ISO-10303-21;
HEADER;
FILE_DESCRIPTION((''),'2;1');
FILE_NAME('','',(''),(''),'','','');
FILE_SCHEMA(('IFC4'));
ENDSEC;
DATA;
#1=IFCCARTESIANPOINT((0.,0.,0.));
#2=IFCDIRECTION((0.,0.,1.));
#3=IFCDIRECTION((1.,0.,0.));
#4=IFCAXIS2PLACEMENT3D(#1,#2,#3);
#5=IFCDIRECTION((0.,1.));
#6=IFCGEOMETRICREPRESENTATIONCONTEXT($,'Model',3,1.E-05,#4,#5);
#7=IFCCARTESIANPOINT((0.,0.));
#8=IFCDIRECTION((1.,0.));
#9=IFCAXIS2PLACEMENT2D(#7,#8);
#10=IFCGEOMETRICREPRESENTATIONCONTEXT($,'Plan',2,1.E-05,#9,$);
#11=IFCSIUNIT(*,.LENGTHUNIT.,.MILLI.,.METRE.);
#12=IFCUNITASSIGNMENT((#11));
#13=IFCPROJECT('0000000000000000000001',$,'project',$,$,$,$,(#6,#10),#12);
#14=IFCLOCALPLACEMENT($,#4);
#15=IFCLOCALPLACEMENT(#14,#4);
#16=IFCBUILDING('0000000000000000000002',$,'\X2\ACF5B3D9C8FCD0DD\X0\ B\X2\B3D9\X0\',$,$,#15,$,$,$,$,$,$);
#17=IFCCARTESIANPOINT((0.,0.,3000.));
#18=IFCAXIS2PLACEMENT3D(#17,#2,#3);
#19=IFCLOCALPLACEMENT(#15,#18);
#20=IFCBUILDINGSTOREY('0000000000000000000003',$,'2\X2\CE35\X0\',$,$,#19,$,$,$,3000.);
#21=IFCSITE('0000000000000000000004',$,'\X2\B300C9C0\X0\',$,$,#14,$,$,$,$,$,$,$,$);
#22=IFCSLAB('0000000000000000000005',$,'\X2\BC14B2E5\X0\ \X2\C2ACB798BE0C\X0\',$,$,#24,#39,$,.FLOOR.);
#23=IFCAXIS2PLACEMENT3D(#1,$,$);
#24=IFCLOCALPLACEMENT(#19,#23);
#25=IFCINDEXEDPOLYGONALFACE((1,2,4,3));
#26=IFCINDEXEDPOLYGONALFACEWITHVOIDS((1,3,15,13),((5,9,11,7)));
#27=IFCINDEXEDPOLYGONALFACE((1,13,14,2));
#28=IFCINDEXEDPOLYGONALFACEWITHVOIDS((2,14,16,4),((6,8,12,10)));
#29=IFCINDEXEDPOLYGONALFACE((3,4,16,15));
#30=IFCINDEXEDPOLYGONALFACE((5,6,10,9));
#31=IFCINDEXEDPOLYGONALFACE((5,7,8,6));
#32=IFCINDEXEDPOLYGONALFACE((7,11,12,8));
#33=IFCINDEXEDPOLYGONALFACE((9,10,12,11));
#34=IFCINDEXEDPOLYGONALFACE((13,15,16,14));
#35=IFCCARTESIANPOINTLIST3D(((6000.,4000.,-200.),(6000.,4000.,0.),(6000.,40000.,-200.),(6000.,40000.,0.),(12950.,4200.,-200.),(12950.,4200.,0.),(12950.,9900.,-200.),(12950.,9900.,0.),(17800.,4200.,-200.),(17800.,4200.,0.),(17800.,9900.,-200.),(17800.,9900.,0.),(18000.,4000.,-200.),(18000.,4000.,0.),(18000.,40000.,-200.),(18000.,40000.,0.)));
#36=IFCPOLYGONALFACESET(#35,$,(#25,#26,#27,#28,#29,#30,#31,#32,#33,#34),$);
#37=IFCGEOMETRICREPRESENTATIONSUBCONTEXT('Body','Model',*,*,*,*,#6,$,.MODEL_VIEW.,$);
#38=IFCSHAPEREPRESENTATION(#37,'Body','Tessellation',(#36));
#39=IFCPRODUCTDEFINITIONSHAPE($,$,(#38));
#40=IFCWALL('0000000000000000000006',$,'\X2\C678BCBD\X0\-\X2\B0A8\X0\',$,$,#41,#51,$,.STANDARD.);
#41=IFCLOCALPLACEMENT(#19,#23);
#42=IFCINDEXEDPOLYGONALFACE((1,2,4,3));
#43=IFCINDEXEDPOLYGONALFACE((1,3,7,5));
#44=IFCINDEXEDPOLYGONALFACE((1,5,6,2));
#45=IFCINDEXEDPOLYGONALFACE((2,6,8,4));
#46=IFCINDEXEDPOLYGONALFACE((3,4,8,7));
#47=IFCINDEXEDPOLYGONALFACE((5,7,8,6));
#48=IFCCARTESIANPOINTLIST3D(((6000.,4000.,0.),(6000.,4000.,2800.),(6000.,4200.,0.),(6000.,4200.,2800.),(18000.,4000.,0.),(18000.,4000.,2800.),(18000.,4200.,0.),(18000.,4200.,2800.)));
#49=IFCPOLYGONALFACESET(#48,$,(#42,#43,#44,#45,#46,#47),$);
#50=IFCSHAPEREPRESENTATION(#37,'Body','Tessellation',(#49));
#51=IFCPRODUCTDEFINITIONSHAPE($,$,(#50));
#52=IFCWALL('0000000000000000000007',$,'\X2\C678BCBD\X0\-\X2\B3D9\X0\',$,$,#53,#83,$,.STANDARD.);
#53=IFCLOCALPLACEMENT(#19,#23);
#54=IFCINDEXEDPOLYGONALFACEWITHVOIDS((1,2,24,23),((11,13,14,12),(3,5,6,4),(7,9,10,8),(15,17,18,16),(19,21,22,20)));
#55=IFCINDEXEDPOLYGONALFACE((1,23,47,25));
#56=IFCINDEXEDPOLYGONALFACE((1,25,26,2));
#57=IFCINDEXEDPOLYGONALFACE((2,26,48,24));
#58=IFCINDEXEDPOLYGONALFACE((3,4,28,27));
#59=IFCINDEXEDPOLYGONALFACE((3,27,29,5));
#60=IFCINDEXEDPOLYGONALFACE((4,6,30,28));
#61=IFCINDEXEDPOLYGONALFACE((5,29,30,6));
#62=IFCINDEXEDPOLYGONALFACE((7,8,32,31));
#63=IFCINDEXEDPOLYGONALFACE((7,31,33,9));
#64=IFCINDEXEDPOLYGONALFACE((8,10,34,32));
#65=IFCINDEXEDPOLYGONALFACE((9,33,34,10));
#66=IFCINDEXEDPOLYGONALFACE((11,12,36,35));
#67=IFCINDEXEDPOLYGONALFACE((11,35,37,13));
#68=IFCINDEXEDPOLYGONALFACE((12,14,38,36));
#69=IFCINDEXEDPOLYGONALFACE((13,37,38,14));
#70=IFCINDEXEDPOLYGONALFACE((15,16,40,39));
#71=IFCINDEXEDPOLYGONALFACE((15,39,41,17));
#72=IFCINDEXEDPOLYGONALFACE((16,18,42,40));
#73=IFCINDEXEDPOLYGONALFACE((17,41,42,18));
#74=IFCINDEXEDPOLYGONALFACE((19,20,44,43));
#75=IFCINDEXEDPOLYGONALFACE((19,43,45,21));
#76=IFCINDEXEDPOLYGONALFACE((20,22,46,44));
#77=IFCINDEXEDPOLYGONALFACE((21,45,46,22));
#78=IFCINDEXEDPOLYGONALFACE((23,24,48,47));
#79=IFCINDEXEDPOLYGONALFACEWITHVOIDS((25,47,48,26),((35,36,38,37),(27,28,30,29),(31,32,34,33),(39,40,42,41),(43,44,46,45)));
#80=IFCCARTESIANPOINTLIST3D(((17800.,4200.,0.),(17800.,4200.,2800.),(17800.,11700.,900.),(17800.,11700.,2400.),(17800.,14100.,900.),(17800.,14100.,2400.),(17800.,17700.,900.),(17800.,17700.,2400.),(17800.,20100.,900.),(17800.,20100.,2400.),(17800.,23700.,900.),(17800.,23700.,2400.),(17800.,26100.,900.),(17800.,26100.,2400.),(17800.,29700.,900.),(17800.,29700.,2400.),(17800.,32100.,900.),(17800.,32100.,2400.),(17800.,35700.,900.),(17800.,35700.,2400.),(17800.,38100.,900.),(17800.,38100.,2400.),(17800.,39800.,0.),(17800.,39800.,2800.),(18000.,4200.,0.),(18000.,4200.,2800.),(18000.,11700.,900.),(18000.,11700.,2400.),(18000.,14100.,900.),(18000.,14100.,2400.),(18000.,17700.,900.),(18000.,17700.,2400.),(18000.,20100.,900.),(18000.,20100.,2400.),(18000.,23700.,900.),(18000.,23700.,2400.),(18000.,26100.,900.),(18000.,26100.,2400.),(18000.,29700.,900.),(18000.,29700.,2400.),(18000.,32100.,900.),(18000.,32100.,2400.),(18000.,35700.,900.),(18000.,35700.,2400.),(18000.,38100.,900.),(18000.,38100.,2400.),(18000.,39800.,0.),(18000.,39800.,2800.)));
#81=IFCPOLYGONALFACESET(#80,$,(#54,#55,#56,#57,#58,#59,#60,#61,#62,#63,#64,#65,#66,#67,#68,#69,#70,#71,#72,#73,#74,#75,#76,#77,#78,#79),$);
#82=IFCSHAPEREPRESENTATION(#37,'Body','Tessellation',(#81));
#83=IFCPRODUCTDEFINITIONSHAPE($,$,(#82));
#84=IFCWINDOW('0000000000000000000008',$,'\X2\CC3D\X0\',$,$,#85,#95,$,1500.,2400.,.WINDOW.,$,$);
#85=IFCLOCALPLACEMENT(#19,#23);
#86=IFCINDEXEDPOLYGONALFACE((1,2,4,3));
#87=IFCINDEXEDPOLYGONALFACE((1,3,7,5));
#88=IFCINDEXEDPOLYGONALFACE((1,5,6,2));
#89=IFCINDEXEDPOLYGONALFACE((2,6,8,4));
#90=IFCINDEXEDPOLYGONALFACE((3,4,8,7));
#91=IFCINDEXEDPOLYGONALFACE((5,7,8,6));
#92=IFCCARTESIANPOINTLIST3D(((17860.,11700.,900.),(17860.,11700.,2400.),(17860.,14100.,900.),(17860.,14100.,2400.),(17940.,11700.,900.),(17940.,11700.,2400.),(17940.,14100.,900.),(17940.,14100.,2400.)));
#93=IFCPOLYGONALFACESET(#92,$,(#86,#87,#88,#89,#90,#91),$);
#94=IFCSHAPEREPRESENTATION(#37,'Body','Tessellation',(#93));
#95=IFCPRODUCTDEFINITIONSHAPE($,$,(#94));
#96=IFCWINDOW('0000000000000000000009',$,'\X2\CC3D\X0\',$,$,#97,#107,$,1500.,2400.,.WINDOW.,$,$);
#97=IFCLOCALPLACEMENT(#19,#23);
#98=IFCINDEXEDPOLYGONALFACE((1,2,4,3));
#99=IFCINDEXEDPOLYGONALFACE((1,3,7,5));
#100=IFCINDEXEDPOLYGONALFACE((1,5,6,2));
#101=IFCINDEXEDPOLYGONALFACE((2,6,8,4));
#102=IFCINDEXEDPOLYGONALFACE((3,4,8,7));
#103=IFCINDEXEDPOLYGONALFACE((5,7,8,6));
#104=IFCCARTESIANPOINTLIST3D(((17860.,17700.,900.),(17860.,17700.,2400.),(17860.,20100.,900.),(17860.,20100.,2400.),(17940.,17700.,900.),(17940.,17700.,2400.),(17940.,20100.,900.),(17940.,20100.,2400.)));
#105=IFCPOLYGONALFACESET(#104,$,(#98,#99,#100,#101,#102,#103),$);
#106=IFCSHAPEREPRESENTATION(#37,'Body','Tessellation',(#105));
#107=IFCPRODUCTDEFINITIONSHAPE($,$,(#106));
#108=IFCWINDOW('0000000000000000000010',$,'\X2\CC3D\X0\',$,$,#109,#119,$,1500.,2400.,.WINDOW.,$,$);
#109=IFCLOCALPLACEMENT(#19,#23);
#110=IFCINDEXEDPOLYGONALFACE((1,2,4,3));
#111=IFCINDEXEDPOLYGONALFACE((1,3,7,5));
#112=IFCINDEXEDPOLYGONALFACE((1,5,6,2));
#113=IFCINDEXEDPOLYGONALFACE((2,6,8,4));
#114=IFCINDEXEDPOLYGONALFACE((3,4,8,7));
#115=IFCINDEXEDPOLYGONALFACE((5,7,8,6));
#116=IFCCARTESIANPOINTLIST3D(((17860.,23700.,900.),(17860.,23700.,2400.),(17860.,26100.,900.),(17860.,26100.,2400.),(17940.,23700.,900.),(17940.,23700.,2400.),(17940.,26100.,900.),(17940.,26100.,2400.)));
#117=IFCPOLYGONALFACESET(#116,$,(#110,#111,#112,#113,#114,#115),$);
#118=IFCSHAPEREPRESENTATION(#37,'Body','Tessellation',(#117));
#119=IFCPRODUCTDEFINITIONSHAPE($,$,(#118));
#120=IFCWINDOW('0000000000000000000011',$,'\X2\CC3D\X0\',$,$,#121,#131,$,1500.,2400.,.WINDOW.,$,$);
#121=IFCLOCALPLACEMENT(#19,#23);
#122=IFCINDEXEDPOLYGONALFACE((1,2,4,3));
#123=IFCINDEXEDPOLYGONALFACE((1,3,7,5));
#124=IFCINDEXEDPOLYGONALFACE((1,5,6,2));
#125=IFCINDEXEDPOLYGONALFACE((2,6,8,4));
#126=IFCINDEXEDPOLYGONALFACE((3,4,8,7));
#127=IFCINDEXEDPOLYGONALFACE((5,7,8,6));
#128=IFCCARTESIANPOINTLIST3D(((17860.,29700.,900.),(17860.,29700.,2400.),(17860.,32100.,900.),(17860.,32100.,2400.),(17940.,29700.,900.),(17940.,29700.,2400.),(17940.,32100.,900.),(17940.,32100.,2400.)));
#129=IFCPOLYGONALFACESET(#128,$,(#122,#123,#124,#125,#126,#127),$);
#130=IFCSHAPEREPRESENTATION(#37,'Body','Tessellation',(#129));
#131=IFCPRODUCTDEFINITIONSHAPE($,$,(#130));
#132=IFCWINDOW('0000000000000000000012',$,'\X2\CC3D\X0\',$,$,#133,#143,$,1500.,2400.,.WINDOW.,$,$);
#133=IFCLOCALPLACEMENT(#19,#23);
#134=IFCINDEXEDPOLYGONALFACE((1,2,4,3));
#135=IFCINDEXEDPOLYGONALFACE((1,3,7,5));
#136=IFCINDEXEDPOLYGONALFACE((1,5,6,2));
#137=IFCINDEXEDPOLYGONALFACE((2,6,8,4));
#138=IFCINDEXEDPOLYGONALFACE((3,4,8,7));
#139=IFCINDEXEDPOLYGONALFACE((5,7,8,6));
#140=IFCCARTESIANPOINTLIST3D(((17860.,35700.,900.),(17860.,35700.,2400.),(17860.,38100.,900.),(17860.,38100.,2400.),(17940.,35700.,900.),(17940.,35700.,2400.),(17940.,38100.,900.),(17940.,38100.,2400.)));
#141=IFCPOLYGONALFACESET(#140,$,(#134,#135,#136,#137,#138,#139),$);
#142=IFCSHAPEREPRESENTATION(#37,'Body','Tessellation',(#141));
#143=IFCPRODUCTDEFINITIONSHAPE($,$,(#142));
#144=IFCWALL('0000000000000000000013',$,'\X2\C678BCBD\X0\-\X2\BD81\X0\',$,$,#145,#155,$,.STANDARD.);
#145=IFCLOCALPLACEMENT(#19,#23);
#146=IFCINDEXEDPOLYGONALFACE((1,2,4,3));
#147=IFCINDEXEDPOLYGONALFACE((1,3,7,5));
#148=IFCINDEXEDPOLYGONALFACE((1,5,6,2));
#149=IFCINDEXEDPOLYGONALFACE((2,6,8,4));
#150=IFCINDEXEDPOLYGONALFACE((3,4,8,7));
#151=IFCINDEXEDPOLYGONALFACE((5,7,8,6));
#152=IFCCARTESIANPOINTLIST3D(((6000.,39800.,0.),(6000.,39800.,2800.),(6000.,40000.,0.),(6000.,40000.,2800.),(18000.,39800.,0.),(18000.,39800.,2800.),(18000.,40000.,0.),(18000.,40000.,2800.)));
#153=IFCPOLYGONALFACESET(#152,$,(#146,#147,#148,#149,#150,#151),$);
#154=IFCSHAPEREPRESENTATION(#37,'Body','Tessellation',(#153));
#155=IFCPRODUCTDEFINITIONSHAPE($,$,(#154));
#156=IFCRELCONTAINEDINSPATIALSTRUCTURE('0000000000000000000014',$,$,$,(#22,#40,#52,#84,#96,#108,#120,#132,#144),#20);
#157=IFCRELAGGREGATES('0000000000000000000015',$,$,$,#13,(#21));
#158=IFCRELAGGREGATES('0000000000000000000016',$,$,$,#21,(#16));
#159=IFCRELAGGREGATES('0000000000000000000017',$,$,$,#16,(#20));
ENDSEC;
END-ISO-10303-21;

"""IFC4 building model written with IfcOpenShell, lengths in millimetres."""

from ifc_helpers import new_model, si_unit, direction, frame, origin_with_axes, origin_2d_with_axis, place, context, subcontext, project, spatial, polyline, outline, extrude, element, fill, save


model = new_model("IFC4")

# Units and contexts
model_context = context("Model", 3, precision=1e-05, world=origin_with_axes(), true_north=direction((0.0, 1.0)))
plan_context = context("Plan", 2, precision=1e-05, world=origin_2d_with_axis())
body_context = subcontext(model_context, "Body", "Model", "MODEL_VIEW")
ifc_project = project(units=[si_unit("LENGTHUNIT", "METRE", prefix="MILLI")], contexts=[model_context, plan_context])

# Site, building, storey
site_placement = place(None, origin_with_axes())
site = spatial("IfcSite", under=ifc_project, at=site_placement, Name="대지")
building_placement = place(site_placement, origin_with_axes())
building = spatial("IfcBuilding", under=site, at=building_placement, Name="공동주택 B동")
storey_placement = place(building_placement, frame((0.0, 0.0, 3000.0), z_axis=(0.0, 0.0, 1.0), x_axis=(1.0, 0.0, 0.0)))
storey = spatial("IfcBuildingStorey", under=building, at=storey_placement, Name="2층", Elevation=3000.0)

# Slab
slab_placement = place(storey_placement, origin_with_axes())
element("IfcSlab", 1, at=slab_placement, inside=storey, Name="바닥 슬래브", PredefinedType="FLOOR", context=body_context, shape_type="SweptSolid", body=[
    extrude(outline(polyline([(6000.0, 4000.0), (18000.0, 4000.0), (18000.0, 40000.0), (6000.0, 40000.0), (6000.0, 4000.0)]), holes=[polyline([(12950.0, 4200.0), (17800.0, 4200.0), (17800.0, 9900.0), (12950.0, 9900.0), (12950.0, 4200.0)])]), frame((0.0, 0.0, -200.0), z_axis=(0.0, 0.0, 1.0), x_axis=(1.0, 0.0, 0.0)), (0.0, 0.0, 1.0), 200.0),
])

# Wall
wall_1_placement = place(storey_placement, origin_with_axes())
element("IfcWall", 2, at=wall_1_placement, inside=storey, Name="외벽-남", PredefinedType="STANDARD", context=body_context, shape_type="SweptSolid", body=[
    extrude(outline(polyline([(6000.0, 4200.0), (18000.0, 4200.0), (18000.0, 4000.0), (6000.0, 4000.0), (6000.0, 4200.0)])), origin_with_axes(), (0.0, 0.0, 1.0), 2800.0),
])

# Wall, openings, windows
wall_2_placement = place(storey_placement, origin_with_axes())
wall_2 = element("IfcWall", 3, at=wall_2_placement, inside=storey, Name="외벽-동", PredefinedType="STANDARD", context=body_context, shape_type="SweptSolid", body=[
    extrude(outline(polyline([(17800.0, 4200.0), (17800.0, 39800.0), (18000.0, 39800.0), (18000.0, 4200.0), (17800.0, 4200.0)])), origin_with_axes(), (0.0, 0.0, 1.0), 2800.0),
])
opening_1_placement = place(storey_placement, origin_with_axes())
opening_1 = element("IfcOpeningElement", 4, at=opening_1_placement, cuts=wall_2, PredefinedType="OPENING", context=body_context, shape_type="SweptSolid", body=[
    extrude(outline(polyline([(18050.0, 11700.0), (18050.0, 14100.0), (17750.0, 14100.0), (17750.0, 11700.0), (18050.0, 11700.0)])), frame((0.0, 0.0, 900.0), z_axis=(0.0, 0.0, 1.0), x_axis=(1.0, 0.0, 0.0)), (0.0, 0.0, 1.0), 1500.0),
])
opening_2_placement = place(storey_placement, origin_with_axes())
opening_2 = element("IfcOpeningElement", 5, at=opening_2_placement, cuts=wall_2, PredefinedType="OPENING", context=body_context, shape_type="SweptSolid", body=[
    extrude(outline(polyline([(18050.0, 17700.0), (18050.0, 20100.0), (17750.0, 20100.0), (17750.0, 17700.0), (18050.0, 17700.0)])), frame((0.0, 0.0, 900.0), z_axis=(0.0, 0.0, 1.0), x_axis=(1.0, 0.0, 0.0)), (0.0, 0.0, 1.0), 1500.0),
])
opening_3_placement = place(storey_placement, origin_with_axes())
opening_3 = element("IfcOpeningElement", 6, at=opening_3_placement, cuts=wall_2, PredefinedType="OPENING", context=body_context, shape_type="SweptSolid", body=[
    extrude(outline(polyline([(18050.0, 23700.0), (18050.0, 26100.0), (17750.0, 26100.0), (17750.0, 23700.0), (18050.0, 23700.0)])), frame((0.0, 0.0, 900.0), z_axis=(0.0, 0.0, 1.0), x_axis=(1.0, 0.0, 0.0)), (0.0, 0.0, 1.0), 1500.0),
])
opening_4_placement = place(storey_placement, origin_with_axes())
opening_4 = element("IfcOpeningElement", 7, at=opening_4_placement, cuts=wall_2, PredefinedType="OPENING", context=body_context, shape_type="SweptSolid", body=[
    extrude(outline(polyline([(18050.0, 29700.0), (18050.0, 32100.0), (17750.0, 32100.0), (17750.0, 29700.0), (18050.0, 29700.0)])), frame((0.0, 0.0, 900.0), z_axis=(0.0, 0.0, 1.0), x_axis=(1.0, 0.0, 0.0)), (0.0, 0.0, 1.0), 1500.0),
])
opening_5_placement = place(storey_placement, origin_with_axes())
opening_5 = element("IfcOpeningElement", 8, at=opening_5_placement, cuts=wall_2, PredefinedType="OPENING", context=body_context, shape_type="SweptSolid", body=[
    extrude(outline(polyline([(18050.0, 35700.0), (18050.0, 38100.0), (17750.0, 38100.0), (17750.0, 35700.0), (18050.0, 35700.0)])), frame((0.0, 0.0, 900.0), z_axis=(0.0, 0.0, 1.0), x_axis=(1.0, 0.0, 0.0)), (0.0, 0.0, 1.0), 1500.0),
])
window_1_placement = place(storey_placement, origin_with_axes())
window_1 = element("IfcWindow", 9, at=window_1_placement, inside=storey, Name="창", OverallHeight=1500.0, OverallWidth=2400.0, PredefinedType="WINDOW", context=body_context, shape_type="SweptSolid", body=[
    extrude(outline(polyline([(17940.0, 11700.0), (17940.0, 14100.0), (17860.0, 14100.0), (17860.0, 11700.0), (17940.0, 11700.0)])), frame((0.0, 0.0, 900.0), z_axis=(0.0, 0.0, 1.0), x_axis=(1.0, 0.0, 0.0)), (0.0, 0.0, 1.0), 1500.0),
])
fill(opening_1, window_1)
window_2_placement = place(storey_placement, origin_with_axes())
window_2 = element("IfcWindow", 10, at=window_2_placement, inside=storey, Name="창", OverallHeight=1500.0, OverallWidth=2400.0, PredefinedType="WINDOW", context=body_context, shape_type="SweptSolid", body=[
    extrude(outline(polyline([(17940.0, 17700.0), (17940.0, 20100.0), (17860.0, 20100.0), (17860.0, 17700.0), (17940.0, 17700.0)])), frame((0.0, 0.0, 900.0), z_axis=(0.0, 0.0, 1.0), x_axis=(1.0, 0.0, 0.0)), (0.0, 0.0, 1.0), 1500.0),
])
fill(opening_2, window_2)
window_3_placement = place(storey_placement, origin_with_axes())
window_3 = element("IfcWindow", 11, at=window_3_placement, inside=storey, Name="창", OverallHeight=1500.0, OverallWidth=2400.0, PredefinedType="WINDOW", context=body_context, shape_type="SweptSolid", body=[
    extrude(outline(polyline([(17940.0, 23700.0), (17940.0, 26100.0), (17860.0, 26100.0), (17860.0, 23700.0), (17940.0, 23700.0)])), frame((0.0, 0.0, 900.0), z_axis=(0.0, 0.0, 1.0), x_axis=(1.0, 0.0, 0.0)), (0.0, 0.0, 1.0), 1500.0),
])
fill(opening_3, window_3)
window_4_placement = place(storey_placement, origin_with_axes())
window_4 = element("IfcWindow", 12, at=window_4_placement, inside=storey, Name="창", OverallHeight=1500.0, OverallWidth=2400.0, PredefinedType="WINDOW", context=body_context, shape_type="SweptSolid", body=[
    extrude(outline(polyline([(17940.0, 29700.0), (17940.0, 32100.0), (17860.0, 32100.0), (17860.0, 29700.0), (17940.0, 29700.0)])), frame((0.0, 0.0, 900.0), z_axis=(0.0, 0.0, 1.0), x_axis=(1.0, 0.0, 0.0)), (0.0, 0.0, 1.0), 1500.0),
])
fill(opening_4, window_4)
window_5_placement = place(storey_placement, origin_with_axes())
window_5 = element("IfcWindow", 13, at=window_5_placement, inside=storey, Name="창", OverallHeight=1500.0, OverallWidth=2400.0, PredefinedType="WINDOW", context=body_context, shape_type="SweptSolid", body=[
    extrude(outline(polyline([(17940.0, 35700.0), (17940.0, 38100.0), (17860.0, 38100.0), (17860.0, 35700.0), (17940.0, 35700.0)])), frame((0.0, 0.0, 900.0), z_axis=(0.0, 0.0, 1.0), x_axis=(1.0, 0.0, 0.0)), (0.0, 0.0, 1.0), 1500.0),
])
fill(opening_5, window_5)

# Wall
wall_3_placement = place(storey_placement, origin_with_axes())
element("IfcWall", 14, at=wall_3_placement, inside=storey, Name="외벽-북", PredefinedType="STANDARD", context=body_context, shape_type="SweptSolid", body=[
    extrude(outline(polyline([(18000.0, 39800.0), (6000.0, 39800.0), (6000.0, 40000.0), (18000.0, 40000.0), (18000.0, 39800.0)])), origin_with_axes(), (0.0, 0.0, 1.0), 2800.0),
])

save(model, "model.ifc")
